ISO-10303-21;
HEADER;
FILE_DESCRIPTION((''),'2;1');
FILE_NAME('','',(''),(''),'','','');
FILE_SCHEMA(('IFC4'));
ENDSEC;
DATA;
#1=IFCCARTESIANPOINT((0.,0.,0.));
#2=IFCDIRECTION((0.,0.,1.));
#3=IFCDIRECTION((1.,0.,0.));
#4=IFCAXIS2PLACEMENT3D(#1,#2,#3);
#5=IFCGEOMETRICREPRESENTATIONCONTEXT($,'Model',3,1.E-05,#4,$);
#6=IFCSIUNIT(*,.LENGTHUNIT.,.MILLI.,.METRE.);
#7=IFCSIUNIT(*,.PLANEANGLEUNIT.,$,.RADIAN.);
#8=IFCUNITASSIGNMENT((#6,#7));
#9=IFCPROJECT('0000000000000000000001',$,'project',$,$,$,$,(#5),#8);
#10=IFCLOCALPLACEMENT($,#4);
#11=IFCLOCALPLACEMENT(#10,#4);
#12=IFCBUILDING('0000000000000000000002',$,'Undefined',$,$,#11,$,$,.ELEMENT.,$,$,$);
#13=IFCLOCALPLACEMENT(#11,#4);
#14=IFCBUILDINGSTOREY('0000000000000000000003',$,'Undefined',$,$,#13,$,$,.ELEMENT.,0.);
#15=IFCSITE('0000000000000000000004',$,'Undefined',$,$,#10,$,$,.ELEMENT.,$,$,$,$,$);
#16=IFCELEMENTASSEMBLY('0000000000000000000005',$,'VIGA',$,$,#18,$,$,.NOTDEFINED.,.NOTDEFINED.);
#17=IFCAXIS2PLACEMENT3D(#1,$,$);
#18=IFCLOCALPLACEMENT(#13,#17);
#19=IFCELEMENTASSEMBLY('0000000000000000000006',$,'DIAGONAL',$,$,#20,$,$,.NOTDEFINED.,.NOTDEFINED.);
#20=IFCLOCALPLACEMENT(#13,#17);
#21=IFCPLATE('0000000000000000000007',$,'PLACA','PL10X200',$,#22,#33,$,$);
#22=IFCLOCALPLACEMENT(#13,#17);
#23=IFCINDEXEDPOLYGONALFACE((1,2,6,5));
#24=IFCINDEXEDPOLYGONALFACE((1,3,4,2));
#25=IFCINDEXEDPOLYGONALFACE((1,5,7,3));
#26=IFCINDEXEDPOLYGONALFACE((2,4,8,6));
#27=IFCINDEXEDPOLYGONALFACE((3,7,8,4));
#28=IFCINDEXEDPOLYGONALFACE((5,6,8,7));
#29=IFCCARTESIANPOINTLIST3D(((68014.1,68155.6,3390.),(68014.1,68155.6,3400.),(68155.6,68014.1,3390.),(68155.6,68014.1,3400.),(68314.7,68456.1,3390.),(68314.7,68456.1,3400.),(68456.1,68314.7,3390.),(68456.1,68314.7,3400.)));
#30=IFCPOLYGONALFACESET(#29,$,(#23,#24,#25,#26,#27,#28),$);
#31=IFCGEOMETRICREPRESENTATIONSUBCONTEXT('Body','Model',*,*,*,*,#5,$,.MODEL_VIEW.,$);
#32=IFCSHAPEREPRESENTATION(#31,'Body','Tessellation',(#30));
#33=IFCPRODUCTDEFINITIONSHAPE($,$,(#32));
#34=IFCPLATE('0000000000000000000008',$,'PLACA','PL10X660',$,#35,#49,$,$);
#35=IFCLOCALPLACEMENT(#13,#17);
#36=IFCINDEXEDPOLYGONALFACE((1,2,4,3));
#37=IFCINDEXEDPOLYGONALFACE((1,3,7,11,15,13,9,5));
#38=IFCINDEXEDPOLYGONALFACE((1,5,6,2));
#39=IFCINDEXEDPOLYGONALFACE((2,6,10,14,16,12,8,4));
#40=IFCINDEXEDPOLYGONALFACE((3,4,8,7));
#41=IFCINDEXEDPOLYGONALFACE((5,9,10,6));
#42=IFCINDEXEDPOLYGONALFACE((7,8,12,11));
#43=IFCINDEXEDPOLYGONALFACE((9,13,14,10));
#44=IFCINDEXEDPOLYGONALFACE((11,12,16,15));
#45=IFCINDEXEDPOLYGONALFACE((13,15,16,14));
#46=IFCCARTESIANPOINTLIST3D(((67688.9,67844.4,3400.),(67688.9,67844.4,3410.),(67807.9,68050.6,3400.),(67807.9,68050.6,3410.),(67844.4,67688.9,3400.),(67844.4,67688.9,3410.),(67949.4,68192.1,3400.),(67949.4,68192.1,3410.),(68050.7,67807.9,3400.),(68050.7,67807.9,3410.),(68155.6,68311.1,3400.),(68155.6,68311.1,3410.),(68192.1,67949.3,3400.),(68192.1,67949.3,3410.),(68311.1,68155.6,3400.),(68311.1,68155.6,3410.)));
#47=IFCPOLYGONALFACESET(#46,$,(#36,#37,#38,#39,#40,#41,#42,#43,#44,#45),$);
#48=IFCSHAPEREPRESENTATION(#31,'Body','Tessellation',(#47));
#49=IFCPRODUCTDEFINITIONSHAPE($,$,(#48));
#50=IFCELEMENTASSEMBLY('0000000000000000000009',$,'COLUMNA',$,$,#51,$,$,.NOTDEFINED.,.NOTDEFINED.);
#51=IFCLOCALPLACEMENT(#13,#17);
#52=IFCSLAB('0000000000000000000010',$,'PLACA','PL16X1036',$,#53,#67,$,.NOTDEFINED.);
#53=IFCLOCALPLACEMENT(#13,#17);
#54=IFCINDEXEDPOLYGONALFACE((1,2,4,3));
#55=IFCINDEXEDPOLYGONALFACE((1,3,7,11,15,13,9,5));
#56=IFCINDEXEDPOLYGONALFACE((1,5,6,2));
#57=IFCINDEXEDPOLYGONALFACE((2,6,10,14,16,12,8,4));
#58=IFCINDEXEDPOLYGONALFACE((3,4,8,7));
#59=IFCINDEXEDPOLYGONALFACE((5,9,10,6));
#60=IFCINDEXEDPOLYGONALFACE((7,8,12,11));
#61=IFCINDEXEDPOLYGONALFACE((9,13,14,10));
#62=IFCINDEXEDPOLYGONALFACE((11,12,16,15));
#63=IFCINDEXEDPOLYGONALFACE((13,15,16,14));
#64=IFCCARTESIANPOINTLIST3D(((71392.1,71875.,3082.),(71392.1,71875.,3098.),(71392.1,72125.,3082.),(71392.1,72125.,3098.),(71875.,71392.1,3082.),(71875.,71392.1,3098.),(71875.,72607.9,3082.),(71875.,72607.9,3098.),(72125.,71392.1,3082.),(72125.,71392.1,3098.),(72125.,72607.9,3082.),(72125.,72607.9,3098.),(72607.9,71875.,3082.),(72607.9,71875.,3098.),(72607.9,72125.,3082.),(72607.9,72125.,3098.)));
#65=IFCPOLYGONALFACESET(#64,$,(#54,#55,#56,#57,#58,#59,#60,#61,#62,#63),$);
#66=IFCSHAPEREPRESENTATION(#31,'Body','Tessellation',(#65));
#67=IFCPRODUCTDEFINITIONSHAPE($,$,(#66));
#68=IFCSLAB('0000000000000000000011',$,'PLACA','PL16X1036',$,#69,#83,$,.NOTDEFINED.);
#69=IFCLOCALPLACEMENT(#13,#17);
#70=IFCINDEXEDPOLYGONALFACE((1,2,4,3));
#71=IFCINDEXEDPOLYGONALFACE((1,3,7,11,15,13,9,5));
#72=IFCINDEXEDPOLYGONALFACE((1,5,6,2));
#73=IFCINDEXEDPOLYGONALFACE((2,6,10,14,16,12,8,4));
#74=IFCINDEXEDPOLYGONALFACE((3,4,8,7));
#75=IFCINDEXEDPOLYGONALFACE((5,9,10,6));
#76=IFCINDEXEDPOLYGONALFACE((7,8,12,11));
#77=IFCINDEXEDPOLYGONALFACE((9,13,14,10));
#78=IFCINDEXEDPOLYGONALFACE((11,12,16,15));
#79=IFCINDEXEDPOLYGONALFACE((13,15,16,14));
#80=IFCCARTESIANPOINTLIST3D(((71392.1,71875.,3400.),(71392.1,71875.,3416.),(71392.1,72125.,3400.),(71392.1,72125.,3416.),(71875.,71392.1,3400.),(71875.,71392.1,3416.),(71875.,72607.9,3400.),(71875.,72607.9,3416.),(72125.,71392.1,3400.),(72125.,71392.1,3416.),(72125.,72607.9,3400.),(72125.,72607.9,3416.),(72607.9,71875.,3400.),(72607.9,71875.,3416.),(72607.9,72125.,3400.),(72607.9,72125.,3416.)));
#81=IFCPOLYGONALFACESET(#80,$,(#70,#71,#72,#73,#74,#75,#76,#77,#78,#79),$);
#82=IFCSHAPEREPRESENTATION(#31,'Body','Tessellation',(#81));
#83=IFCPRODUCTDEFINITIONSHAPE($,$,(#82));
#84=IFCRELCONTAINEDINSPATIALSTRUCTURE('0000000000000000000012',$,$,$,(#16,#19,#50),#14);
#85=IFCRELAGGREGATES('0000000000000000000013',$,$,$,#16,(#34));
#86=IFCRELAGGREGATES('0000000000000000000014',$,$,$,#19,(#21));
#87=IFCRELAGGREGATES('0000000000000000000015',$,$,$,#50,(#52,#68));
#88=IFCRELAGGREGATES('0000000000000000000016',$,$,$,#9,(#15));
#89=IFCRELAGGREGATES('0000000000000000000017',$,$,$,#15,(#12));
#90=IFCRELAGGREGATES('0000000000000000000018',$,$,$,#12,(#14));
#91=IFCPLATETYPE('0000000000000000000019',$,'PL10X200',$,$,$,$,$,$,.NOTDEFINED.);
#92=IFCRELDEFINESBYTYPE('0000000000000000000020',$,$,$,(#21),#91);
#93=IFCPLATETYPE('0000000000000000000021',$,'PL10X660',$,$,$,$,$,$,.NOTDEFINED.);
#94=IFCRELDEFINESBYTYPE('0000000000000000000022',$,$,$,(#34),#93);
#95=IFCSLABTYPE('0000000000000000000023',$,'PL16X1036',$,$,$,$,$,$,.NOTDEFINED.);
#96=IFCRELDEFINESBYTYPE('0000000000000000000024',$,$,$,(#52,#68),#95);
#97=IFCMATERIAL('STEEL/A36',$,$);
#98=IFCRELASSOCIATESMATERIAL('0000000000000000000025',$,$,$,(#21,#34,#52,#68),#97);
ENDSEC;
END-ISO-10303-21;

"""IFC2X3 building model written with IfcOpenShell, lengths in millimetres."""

from ifc_helpers import new_model, si_unit, frame, origin_with_axes, place, context, subcontext, project, spatial, polyline, outline, extrude, material, type_object, element, aggregate, save


model = new_model("IFC2X3")

# Units and contexts
model_context = context("Model", 3, precision=1e-05, world=origin_with_axes())
body_context = subcontext(model_context, "Body", "Model", "MODEL_VIEW")
ifc_project = project(units=[si_unit("LENGTHUNIT", "METRE", prefix="MILLI"), si_unit("PLANEANGLEUNIT", "RADIAN")], contexts=[model_context])

# Site, building, storey
site_placement = place(None, origin_with_axes())
site = spatial("IfcSite", under=ifc_project, at=site_placement, Name="Undefined", CompositionType="ELEMENT")
building_placement = place(site_placement, origin_with_axes())
building = spatial("IfcBuilding", under=site, at=building_placement, Name="Undefined", CompositionType="ELEMENT")
storey_placement = place(building_placement, origin_with_axes())
storey = spatial("IfcBuildingStorey", under=building, at=storey_placement, Name="Undefined", CompositionType="ELEMENT", Elevation=0.0)

# Element assemblies
ifc_material_1 = material(Name="STEEL/A36")
assembly_1_placement = place(storey_placement, origin_with_axes())
assembly_1 = element("IfcElementAssembly", 1, at=assembly_1_placement, inside=storey, Name="VIGA", AssemblyPlace="NOTDEFINED", PredefinedType="NOTDEFINED")
assembly_2_placement = place(storey_placement, origin_with_axes())
assembly_2 = element("IfcElementAssembly", 2, at=assembly_2_placement, inside=storey, Name="DIAGONAL", AssemblyPlace="NOTDEFINED", PredefinedType="NOTDEFINED")

# Plates
plate_type_1 = type_object("IfcPlateType", Name="PL10X200", PredefinedType="NOTDEFINED")
plate_1_placement = place(assembly_2_placement, frame((68084.9, 68084.9, 3395.0), z_axis=(0.0, 0.0, 1.0), x_axis=(0.707107, 0.707107, 0.0)))
plate_1 = element("IfcPlate", 3, at=plate_1_placement, type_object=plate_type_1, material=ifc_material_1, Name="PLACA", Description="PL10X200", context=body_context, shape_type="SweptSolid", body=[
    extrude(outline(polyline([(0.0, -100.0), (0.0, 100.0), (425.0, 100.0), (425.0, -100.0), (0.0, -100.0)])), frame((0.0, 0.0, -5.0), z_axis=(0.0, 0.0, 1.0), x_axis=(1.0, 0.0, 0.0)), (0.0, 0.0, 1.0), 10.0),
])
plate_type_2 = type_object("IfcPlateType", Name="PL10X660", PredefinedType="NOTDEFINED")
plate_2_placement = place(assembly_1_placement, frame((67807.9, 68050.6, 3405.0), z_axis=(0.0, 0.0, -1.0), x_axis=(0.707107, 0.707107, 0.0)))
plate_2 = element("IfcPlate", 4, at=plate_2_placement, type_object=plate_type_2, material=ifc_material_1, Name="PLACA", Description="PL10X660", context=body_context, shape_type="SweptSolid", body=[
    extrude(outline(polyline([(0.0, 0.0), (200.0, 0.0), (430.0, 61.6), (430.0, 281.6), (200.0, 343.3), (0.0, 343.3), (-230.0, 281.6), (-230.0, 61.6), (0.0, 0.0)])), frame((0.0, 0.0, -5.0), z_axis=(0.0, 0.0, 1.0), x_axis=(1.0, 0.0, 0.0)), (0.0, 0.0, 1.0), 10.0),
])
aggregate(assembly_1, [plate_2])

# Element assembly, slabs
assembly_3_placement = place(storey_placement, origin_with_axes())
assembly_3 = element("IfcElementAssembly", 5, at=assembly_3_placement, inside=storey, Name="COLUMNA", AssemblyPlace="NOTDEFINED", PredefinedType="NOTDEFINED")
slab_type = type_object("IfcSlabType", Name="PL16X1036", PredefinedType="NOTDEFINED")
slab_1_placement = place(assembly_3_placement, frame((72125.0, 71392.1, 3090.0), z_axis=(0.0, 0.0, 1.0), x_axis=(0.707107, 0.707107, 0.0)))
slab_1 = element("IfcSlab", 6, at=slab_1_placement, type_object=slab_type, material=ifc_material_1, Name="PLACA", Description="PL16X1036", PredefinedType="NOTDEFINED", context=body_context, shape_type="SweptSolid", body=[
    extrude(outline(polyline([(0.0, 0.0), (682.9, 0.0), (859.7, 176.8), (859.7, 859.7), (682.9, 1036.5), (0.0, 1036.5), (-176.8, 859.7), (-176.8, 176.8), (0.0, 0.0)])), frame((0.0, 0.0, -8.0), z_axis=(0.0, 0.0, 1.0), x_axis=(1.0, 0.0, 0.0)), (0.0, 0.0, 1.0), 16.0),
])
slab_2_placement = place(assembly_3_placement, frame((72125.0, 71392.1, 3408.0), z_axis=(0.0, 0.0, 1.0), x_axis=(0.707107, 0.707107, 0.0)))
slab_2 = element("IfcSlab", 7, at=slab_2_placement, type_object=slab_type, material=ifc_material_1, Name="PLACA", Description="PL16X1036", PredefinedType="NOTDEFINED", context=body_context, shape_type="SweptSolid", body=[
    extrude(outline(polyline([(0.0, 0.0), (682.9, 0.0), (859.7, 176.8), (859.7, 859.7), (682.9, 1036.5), (0.0, 1036.5), (-176.8, 859.7), (-176.8, 176.8), (0.0, 0.0)])), frame((0.0, 0.0, -8.0), z_axis=(0.0, 0.0, 1.0), x_axis=(1.0, 0.0, 0.0)), (0.0, 0.0, 1.0), 16.0),
])

aggregate(assembly_2, [plate_1])
aggregate(assembly_3, [slab_1, slab_2])

save(model, "model.ifc")
